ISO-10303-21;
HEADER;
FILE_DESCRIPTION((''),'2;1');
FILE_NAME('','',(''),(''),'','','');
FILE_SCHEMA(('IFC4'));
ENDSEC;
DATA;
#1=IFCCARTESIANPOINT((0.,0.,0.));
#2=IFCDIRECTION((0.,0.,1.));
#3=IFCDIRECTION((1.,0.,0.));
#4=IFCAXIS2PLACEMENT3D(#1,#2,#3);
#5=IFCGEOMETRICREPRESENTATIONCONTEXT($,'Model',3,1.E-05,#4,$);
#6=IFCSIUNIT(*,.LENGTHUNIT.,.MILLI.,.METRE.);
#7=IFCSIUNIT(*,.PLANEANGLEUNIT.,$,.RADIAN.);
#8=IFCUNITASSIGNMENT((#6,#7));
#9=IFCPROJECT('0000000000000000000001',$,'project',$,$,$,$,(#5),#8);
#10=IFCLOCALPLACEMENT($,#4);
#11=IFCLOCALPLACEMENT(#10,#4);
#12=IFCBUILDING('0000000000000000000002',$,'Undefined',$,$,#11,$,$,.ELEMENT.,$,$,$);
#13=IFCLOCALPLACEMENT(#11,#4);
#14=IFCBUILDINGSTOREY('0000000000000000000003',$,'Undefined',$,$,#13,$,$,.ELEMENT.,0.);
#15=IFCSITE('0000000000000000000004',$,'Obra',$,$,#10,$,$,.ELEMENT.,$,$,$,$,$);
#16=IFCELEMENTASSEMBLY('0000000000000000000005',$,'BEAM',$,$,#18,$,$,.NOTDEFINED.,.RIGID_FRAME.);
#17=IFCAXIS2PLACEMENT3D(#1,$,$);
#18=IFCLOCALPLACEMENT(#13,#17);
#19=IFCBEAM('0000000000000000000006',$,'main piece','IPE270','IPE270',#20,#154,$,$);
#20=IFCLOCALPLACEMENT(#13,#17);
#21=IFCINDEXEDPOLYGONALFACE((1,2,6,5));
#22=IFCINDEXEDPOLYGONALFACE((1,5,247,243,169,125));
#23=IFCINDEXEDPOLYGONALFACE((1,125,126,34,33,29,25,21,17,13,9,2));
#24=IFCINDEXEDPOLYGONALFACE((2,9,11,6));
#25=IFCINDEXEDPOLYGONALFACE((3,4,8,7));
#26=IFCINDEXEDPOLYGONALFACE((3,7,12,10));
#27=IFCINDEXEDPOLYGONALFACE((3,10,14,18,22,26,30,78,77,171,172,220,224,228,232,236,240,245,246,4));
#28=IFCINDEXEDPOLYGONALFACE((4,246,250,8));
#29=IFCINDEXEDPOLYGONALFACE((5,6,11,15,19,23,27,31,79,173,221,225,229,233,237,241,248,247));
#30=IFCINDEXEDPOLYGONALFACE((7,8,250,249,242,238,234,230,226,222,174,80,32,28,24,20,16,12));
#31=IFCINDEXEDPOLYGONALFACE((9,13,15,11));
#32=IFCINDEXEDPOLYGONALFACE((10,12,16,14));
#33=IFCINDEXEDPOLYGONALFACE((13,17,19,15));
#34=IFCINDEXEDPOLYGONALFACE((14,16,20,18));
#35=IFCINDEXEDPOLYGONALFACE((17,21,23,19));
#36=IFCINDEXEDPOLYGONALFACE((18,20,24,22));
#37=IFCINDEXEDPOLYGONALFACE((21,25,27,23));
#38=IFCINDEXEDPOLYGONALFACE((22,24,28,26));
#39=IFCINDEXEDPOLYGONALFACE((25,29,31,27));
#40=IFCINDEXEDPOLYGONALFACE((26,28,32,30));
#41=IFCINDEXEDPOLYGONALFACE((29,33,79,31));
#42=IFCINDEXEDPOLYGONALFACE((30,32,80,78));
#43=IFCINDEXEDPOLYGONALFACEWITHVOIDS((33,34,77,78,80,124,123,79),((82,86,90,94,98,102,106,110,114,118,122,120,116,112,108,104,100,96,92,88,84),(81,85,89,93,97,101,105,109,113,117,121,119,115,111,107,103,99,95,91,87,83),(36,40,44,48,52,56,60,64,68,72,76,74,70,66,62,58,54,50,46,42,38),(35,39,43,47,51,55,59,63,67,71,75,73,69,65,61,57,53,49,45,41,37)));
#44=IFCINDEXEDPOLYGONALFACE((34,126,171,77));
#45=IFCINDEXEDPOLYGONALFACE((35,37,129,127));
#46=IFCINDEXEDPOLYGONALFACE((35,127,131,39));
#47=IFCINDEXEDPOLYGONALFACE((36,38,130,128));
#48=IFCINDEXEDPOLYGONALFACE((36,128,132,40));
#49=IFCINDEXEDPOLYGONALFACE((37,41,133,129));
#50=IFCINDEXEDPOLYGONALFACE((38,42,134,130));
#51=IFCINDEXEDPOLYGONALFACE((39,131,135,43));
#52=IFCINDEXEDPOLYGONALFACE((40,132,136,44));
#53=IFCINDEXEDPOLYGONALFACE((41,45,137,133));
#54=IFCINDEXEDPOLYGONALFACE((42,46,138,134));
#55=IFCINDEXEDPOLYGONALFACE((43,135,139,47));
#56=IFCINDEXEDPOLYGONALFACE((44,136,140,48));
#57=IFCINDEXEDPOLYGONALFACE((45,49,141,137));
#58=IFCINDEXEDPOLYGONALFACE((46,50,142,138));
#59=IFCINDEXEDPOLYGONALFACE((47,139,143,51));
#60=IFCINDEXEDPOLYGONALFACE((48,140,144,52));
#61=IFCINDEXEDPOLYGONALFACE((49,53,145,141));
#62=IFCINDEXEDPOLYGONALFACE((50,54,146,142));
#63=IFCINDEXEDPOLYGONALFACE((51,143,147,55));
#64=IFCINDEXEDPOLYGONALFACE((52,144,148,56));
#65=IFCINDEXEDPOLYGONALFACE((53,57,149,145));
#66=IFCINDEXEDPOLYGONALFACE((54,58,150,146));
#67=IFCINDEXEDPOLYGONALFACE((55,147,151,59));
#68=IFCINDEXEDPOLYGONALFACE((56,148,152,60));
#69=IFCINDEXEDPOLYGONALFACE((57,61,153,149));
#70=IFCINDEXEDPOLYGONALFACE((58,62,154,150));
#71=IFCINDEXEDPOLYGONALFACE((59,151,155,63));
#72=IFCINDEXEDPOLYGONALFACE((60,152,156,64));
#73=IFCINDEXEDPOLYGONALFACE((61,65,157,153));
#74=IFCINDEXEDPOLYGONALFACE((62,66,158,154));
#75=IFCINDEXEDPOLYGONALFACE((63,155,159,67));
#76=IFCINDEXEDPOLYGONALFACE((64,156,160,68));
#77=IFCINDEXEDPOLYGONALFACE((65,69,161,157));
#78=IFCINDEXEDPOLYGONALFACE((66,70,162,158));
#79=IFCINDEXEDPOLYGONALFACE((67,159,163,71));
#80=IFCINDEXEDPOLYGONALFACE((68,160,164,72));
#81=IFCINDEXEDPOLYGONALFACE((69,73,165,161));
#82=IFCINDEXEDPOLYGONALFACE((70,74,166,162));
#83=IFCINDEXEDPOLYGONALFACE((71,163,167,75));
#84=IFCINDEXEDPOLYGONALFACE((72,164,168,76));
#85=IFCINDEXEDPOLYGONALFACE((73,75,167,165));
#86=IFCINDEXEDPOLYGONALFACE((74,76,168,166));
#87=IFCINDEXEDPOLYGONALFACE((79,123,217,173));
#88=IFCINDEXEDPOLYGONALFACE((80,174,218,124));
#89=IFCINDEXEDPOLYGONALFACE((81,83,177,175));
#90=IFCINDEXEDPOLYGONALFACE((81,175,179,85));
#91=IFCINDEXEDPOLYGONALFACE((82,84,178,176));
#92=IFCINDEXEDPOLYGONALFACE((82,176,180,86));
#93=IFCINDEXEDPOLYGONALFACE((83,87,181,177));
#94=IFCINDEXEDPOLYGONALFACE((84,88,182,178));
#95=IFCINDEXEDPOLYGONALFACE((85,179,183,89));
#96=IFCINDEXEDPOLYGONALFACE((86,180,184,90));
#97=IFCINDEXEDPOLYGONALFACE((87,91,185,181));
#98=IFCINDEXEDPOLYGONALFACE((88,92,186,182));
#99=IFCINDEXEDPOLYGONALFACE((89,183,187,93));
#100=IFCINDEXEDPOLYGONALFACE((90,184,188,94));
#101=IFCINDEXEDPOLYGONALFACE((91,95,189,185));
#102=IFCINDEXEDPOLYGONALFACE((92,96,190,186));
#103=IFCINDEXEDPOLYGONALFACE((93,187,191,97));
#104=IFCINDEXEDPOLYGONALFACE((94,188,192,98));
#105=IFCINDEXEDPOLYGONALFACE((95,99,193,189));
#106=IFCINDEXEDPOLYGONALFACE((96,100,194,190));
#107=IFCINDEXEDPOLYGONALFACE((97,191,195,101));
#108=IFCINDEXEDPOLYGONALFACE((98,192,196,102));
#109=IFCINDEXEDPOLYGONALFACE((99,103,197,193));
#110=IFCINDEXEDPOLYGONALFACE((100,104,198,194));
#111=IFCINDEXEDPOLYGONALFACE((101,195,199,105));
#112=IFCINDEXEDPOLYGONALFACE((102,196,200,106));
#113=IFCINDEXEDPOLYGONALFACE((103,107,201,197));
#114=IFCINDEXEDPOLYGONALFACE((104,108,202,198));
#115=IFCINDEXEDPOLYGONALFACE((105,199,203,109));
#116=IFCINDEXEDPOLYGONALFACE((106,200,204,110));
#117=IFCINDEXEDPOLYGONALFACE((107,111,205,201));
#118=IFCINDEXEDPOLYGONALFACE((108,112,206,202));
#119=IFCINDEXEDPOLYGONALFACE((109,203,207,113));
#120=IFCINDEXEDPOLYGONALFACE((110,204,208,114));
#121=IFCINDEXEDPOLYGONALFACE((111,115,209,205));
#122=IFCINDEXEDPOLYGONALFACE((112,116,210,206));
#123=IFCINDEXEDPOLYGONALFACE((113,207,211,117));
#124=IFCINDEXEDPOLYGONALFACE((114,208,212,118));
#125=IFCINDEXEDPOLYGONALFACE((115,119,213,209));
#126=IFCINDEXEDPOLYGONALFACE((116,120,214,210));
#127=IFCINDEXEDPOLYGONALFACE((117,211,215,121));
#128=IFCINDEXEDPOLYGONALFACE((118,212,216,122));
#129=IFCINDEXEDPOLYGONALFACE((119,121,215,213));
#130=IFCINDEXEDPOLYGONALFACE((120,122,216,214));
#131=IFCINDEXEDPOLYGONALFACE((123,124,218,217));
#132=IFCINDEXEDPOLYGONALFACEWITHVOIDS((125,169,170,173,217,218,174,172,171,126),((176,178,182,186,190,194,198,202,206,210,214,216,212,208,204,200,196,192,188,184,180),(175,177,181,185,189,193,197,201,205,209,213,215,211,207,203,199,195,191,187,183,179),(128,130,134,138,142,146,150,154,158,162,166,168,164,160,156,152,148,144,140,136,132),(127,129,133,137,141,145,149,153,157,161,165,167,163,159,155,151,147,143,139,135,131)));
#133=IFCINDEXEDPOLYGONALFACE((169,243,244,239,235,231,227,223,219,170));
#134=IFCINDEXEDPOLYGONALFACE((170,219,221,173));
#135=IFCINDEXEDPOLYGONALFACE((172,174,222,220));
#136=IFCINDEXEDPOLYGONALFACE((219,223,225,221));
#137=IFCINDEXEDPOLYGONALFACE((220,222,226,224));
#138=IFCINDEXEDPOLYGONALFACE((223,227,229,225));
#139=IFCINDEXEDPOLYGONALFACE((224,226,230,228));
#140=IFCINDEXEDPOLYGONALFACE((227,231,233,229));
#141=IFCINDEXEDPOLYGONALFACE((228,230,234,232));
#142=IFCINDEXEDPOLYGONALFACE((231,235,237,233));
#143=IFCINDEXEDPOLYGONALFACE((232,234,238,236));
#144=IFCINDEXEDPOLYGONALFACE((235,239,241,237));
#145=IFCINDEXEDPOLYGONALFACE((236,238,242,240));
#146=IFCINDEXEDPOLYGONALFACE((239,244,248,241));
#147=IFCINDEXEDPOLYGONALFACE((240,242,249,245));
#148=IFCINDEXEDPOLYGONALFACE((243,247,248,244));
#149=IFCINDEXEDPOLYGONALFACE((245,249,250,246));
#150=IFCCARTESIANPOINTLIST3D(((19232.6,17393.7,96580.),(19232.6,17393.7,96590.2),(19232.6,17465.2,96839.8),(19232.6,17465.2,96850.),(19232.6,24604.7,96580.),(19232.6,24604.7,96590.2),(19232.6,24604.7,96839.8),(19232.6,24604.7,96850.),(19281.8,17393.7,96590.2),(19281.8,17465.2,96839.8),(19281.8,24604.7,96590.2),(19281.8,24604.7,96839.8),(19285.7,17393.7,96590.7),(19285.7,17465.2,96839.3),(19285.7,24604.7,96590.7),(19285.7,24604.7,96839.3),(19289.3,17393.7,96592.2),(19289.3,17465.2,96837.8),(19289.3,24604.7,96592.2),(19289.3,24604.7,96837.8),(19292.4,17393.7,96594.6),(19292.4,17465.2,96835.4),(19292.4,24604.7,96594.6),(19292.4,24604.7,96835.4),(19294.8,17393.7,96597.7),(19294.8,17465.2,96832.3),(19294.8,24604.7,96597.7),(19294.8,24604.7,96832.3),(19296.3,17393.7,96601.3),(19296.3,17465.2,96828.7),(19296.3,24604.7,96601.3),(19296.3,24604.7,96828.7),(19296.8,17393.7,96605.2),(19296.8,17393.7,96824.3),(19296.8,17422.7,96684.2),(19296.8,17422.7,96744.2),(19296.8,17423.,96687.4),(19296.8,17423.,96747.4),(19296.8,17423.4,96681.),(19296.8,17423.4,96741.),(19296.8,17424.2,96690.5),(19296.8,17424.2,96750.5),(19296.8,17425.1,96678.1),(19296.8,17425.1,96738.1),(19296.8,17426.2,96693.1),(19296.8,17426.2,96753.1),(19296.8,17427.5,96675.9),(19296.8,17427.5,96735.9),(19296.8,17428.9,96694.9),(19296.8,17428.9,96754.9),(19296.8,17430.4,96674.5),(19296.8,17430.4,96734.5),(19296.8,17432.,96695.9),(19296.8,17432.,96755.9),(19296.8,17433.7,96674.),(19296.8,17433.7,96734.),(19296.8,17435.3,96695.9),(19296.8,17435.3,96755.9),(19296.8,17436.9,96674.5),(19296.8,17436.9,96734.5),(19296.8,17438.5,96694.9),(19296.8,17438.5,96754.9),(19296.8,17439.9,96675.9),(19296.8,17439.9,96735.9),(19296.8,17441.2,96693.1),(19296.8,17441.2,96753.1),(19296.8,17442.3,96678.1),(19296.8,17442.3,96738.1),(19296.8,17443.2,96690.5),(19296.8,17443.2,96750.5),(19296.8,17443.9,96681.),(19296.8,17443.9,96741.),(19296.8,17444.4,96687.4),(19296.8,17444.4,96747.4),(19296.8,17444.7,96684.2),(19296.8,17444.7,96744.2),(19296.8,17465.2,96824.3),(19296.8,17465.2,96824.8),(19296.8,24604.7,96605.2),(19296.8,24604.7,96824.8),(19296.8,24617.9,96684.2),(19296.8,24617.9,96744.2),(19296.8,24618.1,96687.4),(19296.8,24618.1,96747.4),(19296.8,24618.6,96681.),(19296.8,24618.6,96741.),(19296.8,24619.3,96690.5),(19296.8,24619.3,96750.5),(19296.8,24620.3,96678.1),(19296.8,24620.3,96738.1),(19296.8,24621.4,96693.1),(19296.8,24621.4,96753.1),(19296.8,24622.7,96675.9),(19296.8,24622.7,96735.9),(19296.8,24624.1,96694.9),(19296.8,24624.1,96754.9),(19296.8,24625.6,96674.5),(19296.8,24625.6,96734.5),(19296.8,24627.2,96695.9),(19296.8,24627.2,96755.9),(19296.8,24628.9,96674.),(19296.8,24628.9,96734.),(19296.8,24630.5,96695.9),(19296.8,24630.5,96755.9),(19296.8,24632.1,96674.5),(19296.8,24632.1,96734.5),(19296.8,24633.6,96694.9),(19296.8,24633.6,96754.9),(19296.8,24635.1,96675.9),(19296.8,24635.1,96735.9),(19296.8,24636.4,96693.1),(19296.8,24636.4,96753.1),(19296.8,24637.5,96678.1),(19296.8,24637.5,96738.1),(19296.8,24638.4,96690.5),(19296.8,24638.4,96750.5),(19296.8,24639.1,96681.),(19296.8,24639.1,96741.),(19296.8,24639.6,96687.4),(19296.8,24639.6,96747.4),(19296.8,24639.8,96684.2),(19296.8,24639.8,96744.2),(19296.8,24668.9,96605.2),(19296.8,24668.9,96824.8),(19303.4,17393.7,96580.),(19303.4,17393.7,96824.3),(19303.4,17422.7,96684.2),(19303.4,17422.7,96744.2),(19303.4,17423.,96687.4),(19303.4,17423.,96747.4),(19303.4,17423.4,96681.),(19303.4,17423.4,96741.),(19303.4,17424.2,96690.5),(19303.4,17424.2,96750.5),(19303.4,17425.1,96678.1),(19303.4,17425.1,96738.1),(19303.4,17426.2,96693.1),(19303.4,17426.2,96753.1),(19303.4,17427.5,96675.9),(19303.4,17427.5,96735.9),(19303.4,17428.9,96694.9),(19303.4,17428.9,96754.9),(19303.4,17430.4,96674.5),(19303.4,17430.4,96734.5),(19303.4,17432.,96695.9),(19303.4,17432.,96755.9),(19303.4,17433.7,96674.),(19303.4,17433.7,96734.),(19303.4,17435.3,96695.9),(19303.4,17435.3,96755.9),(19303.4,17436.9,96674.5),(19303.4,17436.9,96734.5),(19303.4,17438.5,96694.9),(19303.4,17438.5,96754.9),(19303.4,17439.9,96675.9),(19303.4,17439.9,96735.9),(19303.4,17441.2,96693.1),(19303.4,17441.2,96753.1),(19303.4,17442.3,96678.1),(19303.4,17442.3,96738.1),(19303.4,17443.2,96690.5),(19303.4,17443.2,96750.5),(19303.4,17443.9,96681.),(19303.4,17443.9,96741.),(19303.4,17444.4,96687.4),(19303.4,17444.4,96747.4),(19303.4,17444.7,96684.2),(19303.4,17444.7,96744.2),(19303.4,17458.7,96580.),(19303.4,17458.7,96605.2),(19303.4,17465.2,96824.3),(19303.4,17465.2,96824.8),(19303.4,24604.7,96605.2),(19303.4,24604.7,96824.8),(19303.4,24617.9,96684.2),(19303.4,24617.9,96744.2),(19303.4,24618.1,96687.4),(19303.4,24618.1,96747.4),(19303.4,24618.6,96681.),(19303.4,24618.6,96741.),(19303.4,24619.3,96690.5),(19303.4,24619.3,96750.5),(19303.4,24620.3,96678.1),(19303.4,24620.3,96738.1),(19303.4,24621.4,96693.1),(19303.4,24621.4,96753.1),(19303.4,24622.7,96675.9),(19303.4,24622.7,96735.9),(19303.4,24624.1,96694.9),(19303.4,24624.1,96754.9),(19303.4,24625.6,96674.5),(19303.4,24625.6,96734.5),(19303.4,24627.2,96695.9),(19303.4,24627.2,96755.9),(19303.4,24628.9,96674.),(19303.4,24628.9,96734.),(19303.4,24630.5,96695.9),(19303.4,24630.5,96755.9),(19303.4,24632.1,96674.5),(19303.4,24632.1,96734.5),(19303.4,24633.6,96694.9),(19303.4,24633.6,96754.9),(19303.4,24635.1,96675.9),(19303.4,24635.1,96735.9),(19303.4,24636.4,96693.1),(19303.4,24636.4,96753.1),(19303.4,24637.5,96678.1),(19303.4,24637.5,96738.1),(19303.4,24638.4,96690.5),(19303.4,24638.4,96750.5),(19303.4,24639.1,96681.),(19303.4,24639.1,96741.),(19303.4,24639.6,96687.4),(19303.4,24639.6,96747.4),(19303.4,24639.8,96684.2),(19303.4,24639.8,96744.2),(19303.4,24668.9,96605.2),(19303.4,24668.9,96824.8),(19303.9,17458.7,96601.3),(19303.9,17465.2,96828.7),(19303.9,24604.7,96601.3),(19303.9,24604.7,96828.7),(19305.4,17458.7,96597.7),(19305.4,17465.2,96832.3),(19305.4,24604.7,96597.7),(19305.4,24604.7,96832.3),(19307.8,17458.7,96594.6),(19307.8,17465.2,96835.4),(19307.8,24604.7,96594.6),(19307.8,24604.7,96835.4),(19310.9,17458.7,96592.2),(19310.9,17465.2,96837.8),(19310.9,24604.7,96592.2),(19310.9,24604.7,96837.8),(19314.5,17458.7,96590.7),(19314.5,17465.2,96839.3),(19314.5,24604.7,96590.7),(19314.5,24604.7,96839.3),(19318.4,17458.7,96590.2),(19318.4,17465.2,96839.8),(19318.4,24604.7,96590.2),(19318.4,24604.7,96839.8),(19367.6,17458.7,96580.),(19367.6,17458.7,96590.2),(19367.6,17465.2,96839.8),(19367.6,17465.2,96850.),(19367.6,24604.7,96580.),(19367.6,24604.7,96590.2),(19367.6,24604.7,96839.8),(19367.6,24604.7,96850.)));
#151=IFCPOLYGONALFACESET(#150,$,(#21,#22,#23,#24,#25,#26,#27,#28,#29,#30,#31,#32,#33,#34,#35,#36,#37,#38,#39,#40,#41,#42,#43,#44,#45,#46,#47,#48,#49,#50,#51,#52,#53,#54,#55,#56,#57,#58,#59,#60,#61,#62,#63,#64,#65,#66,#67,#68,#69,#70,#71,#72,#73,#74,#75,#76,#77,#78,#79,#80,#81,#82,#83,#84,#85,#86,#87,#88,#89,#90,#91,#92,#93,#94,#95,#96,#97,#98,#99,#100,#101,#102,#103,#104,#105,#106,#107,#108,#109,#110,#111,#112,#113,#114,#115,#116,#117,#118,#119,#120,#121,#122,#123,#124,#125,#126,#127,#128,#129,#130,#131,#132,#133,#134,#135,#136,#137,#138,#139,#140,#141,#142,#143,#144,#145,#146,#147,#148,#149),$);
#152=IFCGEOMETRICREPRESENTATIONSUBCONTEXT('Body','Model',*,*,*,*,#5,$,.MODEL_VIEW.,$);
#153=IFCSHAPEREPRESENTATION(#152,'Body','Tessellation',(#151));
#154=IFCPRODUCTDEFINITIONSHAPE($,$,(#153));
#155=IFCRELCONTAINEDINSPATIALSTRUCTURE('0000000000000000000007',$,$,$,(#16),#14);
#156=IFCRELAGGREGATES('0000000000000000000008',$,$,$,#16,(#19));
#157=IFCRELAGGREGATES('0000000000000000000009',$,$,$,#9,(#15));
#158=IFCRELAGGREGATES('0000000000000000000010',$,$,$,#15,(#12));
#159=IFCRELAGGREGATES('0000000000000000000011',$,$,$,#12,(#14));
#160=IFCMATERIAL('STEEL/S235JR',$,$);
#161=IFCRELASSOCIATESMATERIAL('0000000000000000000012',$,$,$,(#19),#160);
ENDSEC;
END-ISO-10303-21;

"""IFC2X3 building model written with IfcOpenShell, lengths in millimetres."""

from ifc_helpers import new_model, si_unit, frame, origin_with_axes, origin_2d_with_axis, place, context, subcontext, project, spatial, rectangle, circle, i_section, extrude, clip, halfspace, source, transform, mapped, material, element, aggregate, save


model = new_model("IFC2X3")

# Units and contexts
model_context = context("Model", 3, precision=1e-05, world=origin_with_axes())
body_context = subcontext(model_context, "Body", "Model", "MODEL_VIEW")
ifc_project = project(units=[si_unit("LENGTHUNIT", "METRE", prefix="MILLI"), si_unit("PLANEANGLEUNIT", "RADIAN")], contexts=[model_context])

# Site, building, storey
site_placement = place(None, origin_with_axes())
site = spatial("IfcSite", under=ifc_project, at=site_placement, Name="Obra", CompositionType="ELEMENT")
building_placement = place(site_placement, origin_with_axes())
building = spatial("IfcBuilding", under=site, at=building_placement, Name="Undefined", CompositionType="ELEMENT")
storey_placement = place(building_placement, origin_with_axes())
storey = spatial("IfcBuildingStorey", under=building, at=storey_placement, Name="Undefined", CompositionType="ELEMENT", Elevation=0.0)

# Shared definitions
ifc_material = material(Name="STEEL/S235JR")

# Element assembly, beam, openings
assembly_1_placement = place(storey_placement, origin_with_axes())
assembly_1 = element("IfcElementAssembly", 1, at=assembly_1_placement, inside=storey, Name="BEAM", AssemblyPlace="NOTDEFINED", PredefinedType="RIGID_FRAME")
beam_1_placement = place(assembly_1_placement, frame((19300.1, 17475.1, 96715.0), z_axis=(0.0, 0.0, 1.0), x_axis=(0.0, 1.0, 0.0)))
beam_1 = element("IfcBeam", 2, at=beam_1_placement, material=ifc_material, Name="main piece", Description="IPE270", ObjectType="IPE270", context=body_context, shape_type="Clipping", body=[
    clip(clip(extrude(i_section(OverallWidth=135.0, OverallDepth=270.0, WebThickness=6.6, FlangeThickness=10.2, FilletRadius=15.0, at=origin_2d_with_axis()), frame((7193.7, 0.0, 0.0), z_axis=(-1.0, 0.0, 0.0), x_axis=(0.0, -1.0, 0.0)), (0.0, 0.0, 1.0), 7275.2), halfspace(frame((7193.7, 0.0, -235.0), z_axis=(-1.0, -0.000002, 0.0), x_axis=(-0.000002, 1.0, 0.0)), True)), halfspace(frame((-81.4, 0.0, -235.0), z_axis=(1.0, 0.0, 0.0), x_axis=(0.0, -1.0, 0.0)), True)),
])
opening_1_placement = place(assembly_1_placement, frame((19300.1, 17475.1, 96715.0), z_axis=(0.0, 0.0, 1.0), x_axis=(0.0, 1.0, 0.0)))
element("IfcOpeningElement", 3, at=opening_1_placement, cuts=beam_1, ObjectType="Recess", context=body_context, shape_type="SweptSolid", body=[
    extrude(rectangle(XDim=26.2, YDim=76.2, at=origin_2d_with_axis()), frame((7167.6, 68.5, -122.9), z_axis=(0.000002, -1.0, 0.0), x_axis=(0.0, 0.0, -1.0)), (0.0, 0.0, 1.0), 137.0),
])
opening_2_placement = place(assembly_1_placement, frame((19300.1, 17475.1, 96715.0), z_axis=(0.0, 0.0, 1.0), x_axis=(0.0, 1.0, 0.0)))
element("IfcOpeningElement", 4, at=opening_2_placement, cuts=beam_1, ObjectType="Recess", context=body_context, shape_type="SweptSolid", body=[
    extrude(rectangle(XDim=26.2, YDim=76.2, at=origin_2d_with_axis()), frame((7167.6, 68.5, 122.9), z_axis=(0.000002, -1.0, 0.0), x_axis=(0.0, 0.0, -1.0)), (0.0, 0.0, 1.0), 137.0),
])
opening_3_placement = place(assembly_1_placement, frame((19300.1, 17475.1, 96715.0), z_axis=(0.0, 0.0, 1.0), x_axis=(0.0, 1.0, 0.0)))
element("IfcOpeningElement", 5, at=opening_3_placement, cuts=beam_1, ObjectType="Recess", context=body_context, shape_type="SweptSolid", body=[
    extrude(rectangle(XDim=75.0, YDim=300.0, at=origin_2d_with_axis()), frame((-53.9, -153.3, 124.3), z_axis=(0.0, 0.0, -1.0), x_axis=(1.0, 0.0, 0.0)), (0.0, 0.0, 1.0), 278.6),
])
opening_4_placement = place(assembly_1_placement, frame((19300.1, 17475.1, 96715.0), z_axis=(0.0, 0.0, 1.0), x_axis=(0.0, 1.0, 0.0)))
element("IfcOpeningElement", 6, at=opening_4_placement, cuts=beam_1, ObjectType="Recess", context=body_context, shape_type="SweptSolid", body=[
    extrude(rectangle(XDim=26.7, YDim=83.5, at=origin_2d_with_axis()), frame((-51.7, -68.5, 122.7), z_axis=(0.0, 1.0, 0.0), x_axis=(0.0, 0.0, -1.0)), (0.0, 0.0, 1.0), 137.0),
])
shared_shape_1 = source(origin_with_axes(), body_context, "Body", "SweptSolid", [
    extrude(circle(Radius=11.0, at=origin_2d_with_axis()), frame((0.0, -3.4, 0.0), z_axis=(0.0, 1.0, 0.0), x_axis=(1.0, 0.0, 0.0)), (0.0, 0.0, 1.0), 6.8),
])
opening_5_placement = place(assembly_1_placement, frame((19300.1, 24668.9, 96850.0), z_axis=(0.000002, -1.0, 0.0), x_axis=(0.0, 0.0, -1.0)))
element("IfcOpeningElement", 7, at=opening_5_placement, cuts=beam_1, ObjectType="Opening", context=body_context, shape_type="MappedRepresentation", body=[
    mapped(shared_shape_1, transform((105.0, 0.0, 40.0))),
    mapped(shared_shape_1, transform((165.0, 0.0, 40.0))),
])
opening_6_placement = place(assembly_1_placement, frame((19300.1, 17393.7, 96850.0), z_axis=(0.0, 1.0, 0.0), x_axis=(0.0, 0.0, -1.0)))
element("IfcOpeningElement", 8, at=opening_6_placement, cuts=beam_1, ObjectType="Opening", context=body_context, shape_type="MappedRepresentation", body=[
    mapped(shared_shape_1, transform((105.0, 0.0, 40.0))),
    mapped(shared_shape_1, transform((165.0, 0.0, 40.0))),
])
aggregate(assembly_1, [beam_1])

save(model, "model.ifc")
